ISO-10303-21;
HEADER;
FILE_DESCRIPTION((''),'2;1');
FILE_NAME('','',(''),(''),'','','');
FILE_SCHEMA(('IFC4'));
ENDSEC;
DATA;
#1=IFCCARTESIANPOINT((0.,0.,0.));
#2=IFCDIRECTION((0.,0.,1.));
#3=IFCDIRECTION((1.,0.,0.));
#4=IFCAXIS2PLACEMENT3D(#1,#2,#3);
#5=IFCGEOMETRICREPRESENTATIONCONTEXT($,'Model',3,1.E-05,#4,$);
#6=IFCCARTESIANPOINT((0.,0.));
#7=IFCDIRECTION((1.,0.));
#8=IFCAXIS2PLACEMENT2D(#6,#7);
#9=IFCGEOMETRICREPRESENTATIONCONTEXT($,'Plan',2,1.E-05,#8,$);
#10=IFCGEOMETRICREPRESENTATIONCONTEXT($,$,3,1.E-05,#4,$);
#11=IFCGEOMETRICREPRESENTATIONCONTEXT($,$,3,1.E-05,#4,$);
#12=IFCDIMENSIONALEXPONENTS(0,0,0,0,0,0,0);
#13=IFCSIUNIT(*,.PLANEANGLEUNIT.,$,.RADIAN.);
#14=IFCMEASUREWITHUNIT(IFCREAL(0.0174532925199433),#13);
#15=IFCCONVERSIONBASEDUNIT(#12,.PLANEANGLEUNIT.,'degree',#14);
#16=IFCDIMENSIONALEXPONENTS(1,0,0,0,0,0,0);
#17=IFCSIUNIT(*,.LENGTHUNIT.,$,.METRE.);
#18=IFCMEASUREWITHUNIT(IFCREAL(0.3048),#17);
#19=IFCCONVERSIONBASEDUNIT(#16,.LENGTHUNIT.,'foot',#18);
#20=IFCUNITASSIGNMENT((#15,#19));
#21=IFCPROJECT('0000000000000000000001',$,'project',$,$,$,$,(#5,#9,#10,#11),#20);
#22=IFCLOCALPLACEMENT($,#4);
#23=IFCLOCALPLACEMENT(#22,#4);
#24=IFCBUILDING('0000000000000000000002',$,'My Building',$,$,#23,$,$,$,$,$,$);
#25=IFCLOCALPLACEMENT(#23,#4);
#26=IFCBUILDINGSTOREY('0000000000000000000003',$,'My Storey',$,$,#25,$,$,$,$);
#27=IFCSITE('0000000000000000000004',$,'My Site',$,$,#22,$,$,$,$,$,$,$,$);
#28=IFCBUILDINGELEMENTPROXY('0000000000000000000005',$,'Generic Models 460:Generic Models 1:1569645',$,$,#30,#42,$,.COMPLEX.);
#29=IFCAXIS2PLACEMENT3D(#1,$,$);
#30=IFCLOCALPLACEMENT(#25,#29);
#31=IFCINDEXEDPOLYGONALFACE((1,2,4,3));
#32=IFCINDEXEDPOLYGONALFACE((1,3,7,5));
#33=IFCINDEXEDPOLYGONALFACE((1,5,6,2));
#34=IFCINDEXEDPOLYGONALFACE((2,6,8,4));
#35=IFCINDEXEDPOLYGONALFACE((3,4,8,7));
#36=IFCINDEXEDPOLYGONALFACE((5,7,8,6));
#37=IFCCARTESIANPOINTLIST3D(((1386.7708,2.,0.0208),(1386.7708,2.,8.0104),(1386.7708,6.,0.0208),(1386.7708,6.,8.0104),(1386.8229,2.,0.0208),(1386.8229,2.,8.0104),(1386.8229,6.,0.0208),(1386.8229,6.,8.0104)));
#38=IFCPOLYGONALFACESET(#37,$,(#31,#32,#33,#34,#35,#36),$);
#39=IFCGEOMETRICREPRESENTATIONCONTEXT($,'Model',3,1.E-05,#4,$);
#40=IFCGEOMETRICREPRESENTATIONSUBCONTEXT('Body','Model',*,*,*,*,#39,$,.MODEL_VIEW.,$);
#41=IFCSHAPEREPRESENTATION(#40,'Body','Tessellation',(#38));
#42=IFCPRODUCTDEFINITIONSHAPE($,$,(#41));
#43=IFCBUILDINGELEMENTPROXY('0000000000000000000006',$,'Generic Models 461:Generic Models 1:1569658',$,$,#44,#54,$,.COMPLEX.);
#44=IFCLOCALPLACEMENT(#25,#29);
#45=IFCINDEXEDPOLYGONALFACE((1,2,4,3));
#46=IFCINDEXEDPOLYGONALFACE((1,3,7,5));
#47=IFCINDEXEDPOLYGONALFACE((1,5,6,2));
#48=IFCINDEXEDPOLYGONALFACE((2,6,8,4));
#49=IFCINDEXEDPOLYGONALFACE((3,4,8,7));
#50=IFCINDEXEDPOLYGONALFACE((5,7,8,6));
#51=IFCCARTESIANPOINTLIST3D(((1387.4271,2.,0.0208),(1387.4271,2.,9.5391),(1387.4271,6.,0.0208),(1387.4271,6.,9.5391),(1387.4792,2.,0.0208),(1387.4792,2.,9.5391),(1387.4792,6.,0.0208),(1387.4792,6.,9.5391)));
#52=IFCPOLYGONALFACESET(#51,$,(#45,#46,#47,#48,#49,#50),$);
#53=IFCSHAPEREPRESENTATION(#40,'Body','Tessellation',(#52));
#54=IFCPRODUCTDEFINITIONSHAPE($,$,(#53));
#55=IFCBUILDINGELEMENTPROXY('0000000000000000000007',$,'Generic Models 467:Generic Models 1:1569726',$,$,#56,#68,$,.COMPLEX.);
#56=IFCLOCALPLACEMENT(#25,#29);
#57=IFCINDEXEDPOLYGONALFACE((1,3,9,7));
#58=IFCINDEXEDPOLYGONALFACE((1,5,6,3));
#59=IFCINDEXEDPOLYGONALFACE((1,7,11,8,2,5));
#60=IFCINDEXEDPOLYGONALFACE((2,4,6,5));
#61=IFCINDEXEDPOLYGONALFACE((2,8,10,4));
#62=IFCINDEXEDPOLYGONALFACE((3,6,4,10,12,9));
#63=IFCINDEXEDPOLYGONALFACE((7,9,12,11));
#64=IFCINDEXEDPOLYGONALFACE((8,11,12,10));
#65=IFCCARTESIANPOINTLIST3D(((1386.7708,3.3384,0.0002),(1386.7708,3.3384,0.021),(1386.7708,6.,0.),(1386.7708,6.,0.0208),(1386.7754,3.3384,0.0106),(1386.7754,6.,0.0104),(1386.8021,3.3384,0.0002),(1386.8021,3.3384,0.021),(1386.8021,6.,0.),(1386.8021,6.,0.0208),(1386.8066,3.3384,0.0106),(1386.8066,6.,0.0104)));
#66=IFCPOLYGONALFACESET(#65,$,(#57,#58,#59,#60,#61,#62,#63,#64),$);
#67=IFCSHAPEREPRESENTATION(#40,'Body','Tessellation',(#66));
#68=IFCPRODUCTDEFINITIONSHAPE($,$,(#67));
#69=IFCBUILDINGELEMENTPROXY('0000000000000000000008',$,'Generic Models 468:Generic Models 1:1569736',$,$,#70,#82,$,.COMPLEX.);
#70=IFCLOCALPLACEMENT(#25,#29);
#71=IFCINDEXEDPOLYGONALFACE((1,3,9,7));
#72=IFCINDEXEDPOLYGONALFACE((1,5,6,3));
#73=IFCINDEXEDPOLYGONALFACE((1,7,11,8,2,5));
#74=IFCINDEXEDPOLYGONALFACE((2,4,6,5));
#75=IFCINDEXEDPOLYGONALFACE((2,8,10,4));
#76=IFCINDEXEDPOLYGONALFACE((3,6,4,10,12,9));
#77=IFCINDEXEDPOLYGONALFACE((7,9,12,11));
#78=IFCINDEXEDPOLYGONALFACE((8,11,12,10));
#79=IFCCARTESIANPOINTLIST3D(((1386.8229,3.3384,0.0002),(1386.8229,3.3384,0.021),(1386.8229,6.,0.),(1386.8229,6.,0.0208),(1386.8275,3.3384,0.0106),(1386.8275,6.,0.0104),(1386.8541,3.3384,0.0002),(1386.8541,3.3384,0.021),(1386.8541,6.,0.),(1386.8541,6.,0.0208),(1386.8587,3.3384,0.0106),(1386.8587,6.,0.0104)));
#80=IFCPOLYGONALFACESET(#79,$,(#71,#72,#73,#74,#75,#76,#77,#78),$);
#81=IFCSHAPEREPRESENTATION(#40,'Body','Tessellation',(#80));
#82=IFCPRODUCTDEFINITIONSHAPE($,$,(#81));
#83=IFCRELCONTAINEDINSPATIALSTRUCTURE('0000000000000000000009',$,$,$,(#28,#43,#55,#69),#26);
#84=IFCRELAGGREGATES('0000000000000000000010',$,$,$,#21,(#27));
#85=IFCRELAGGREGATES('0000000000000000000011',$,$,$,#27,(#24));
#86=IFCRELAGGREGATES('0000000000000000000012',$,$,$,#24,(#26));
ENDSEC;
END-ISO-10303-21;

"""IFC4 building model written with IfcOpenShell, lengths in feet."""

from ifc_helpers import new_model, entity, si_unit, converted_unit, frame, origin_with_axes, origin_2d_with_axis, place, context, subcontext, project, spatial, polyline, outline, extrude, element, save


model = new_model("IFC4")

# Units and contexts
model_context_1 = context("Model", 3, precision=1e-05, world=origin_with_axes())
plan_context = context("Plan", 2, precision=1e-05, world=origin_2d_with_axis())
model_context_2 = context("Model", 3, precision=1e-05, world=origin_with_axes())
context_of_model_1 = context(None, 3, precision=1e-05, world=origin_with_axes())
context_of_model_2 = context(None, 3, precision=1e-05, world=origin_with_axes())
body_context = subcontext(model_context_2, "Body", "Model", "MODEL_VIEW")
ifc_project = project(units=[converted_unit("PLANEANGLEUNIT", "degree", entity("IfcReal", 0.0174532925199433), si_unit("PLANEANGLEUNIT", "RADIAN"), dimensions=[0, 0, 0, 0, 0, 0, 0]), converted_unit("LENGTHUNIT", "foot", entity("IfcReal", 0.3048), si_unit("LENGTHUNIT", "METRE"), dimensions=[1, 0, 0, 0, 0, 0, 0])], contexts=[model_context_1, plan_context, context_of_model_1, context_of_model_2])

# Site, building, storey
site_placement = place(None, origin_with_axes())
site = spatial("IfcSite", under=ifc_project, at=site_placement, Name="My Site")
building_placement = place(site_placement, origin_with_axes())
building = spatial("IfcBuilding", under=site, at=building_placement, Name="My Building")
storey_placement = place(building_placement, origin_with_axes())
storey = spatial("IfcBuildingStorey", under=building, at=storey_placement, Name="My Storey")

# Building element proxies
proxy_1_placement = place(storey_placement, frame((1386.7708, 6.0, 0.0208), z_axis=(0.0, -1.0, 0.0), x_axis=(0.0, 0.0, 1.0)))
element("IfcBuildingElementProxy", 1, at=proxy_1_placement, inside=storey, Name="Generic Models 460:Generic Models 1:1569645", PredefinedType="COMPLEX", context=body_context, shape_type="SweptSolid", body=[
    extrude(outline(polyline([(-3.9948, -0.026), (3.9948, -0.026), (3.9948, 0.026), (-3.9948, 0.026), (-3.9948, -0.026)])), frame((3.9948, -0.026, 0.0), z_axis=(0.0, 0.0, -1.0), x_axis=(1.0, 0.0, 0.0)), (0.0, 0.0, -1.0), 4.0),
])
proxy_2_placement = place(storey_placement, frame((1387.4271, 6.0, 0.0208), z_axis=(0.0, -1.0, 0.0), x_axis=(0.0, 0.0, 1.0)))
element("IfcBuildingElementProxy", 2, at=proxy_2_placement, inside=storey, Name="Generic Models 461:Generic Models 1:1569658", PredefinedType="COMPLEX", context=body_context, shape_type="SweptSolid", body=[
    extrude(outline(polyline([(-4.7591, -0.026), (4.7591, -0.026), (4.7591, 0.026), (-4.7591, 0.026), (-4.7591, -0.026)])), frame((4.7591, -0.026, 0.0), z_axis=(0.0, 0.0, -1.0), x_axis=(-1.0, 0.0, 0.0)), (0.0, 0.0, -1.0), 4.0),
])
for number, where, z_axis, x_axis, name in (
    (3, (1386.7708, 6.0, 0.0), (0.0, -1.0, 0.0), (0.0, 0.0, 1.0), "Generic Models 467:Generic Models 1:1569726"),
    (4, (1386.8229, 6.0, 0.0), (0.0, -1.0, 0.0), (0.0, 0.0, 1.0), "Generic Models 468:Generic Models 1:1569736"),
):
    element("IfcBuildingElementProxy", number, at=place(storey_placement, frame(where, z_axis=z_axis, x_axis=x_axis)), inside=storey, Name=name, PredefinedType="COMPLEX", context=body_context, shape_type="SweptSolid", body=[
        extrude(outline(polyline([(0.0201, 0.0), (-0.0066, 0.0162), (-0.016, 0.0097), (-0.0175, -0.0016), (0.0093, -0.0178), (0.0107, -0.0065), (0.0201, 0.0)])), frame((0.0104, -0.0172, 0.0), z_axis=(0.0, 0.0, -1.0), x_axis=(0.51911, 0.854708, 0.0)), (0.000035, 0.000056, -1.0), 2.6616),
    ])

save(model, "model.ifc")
